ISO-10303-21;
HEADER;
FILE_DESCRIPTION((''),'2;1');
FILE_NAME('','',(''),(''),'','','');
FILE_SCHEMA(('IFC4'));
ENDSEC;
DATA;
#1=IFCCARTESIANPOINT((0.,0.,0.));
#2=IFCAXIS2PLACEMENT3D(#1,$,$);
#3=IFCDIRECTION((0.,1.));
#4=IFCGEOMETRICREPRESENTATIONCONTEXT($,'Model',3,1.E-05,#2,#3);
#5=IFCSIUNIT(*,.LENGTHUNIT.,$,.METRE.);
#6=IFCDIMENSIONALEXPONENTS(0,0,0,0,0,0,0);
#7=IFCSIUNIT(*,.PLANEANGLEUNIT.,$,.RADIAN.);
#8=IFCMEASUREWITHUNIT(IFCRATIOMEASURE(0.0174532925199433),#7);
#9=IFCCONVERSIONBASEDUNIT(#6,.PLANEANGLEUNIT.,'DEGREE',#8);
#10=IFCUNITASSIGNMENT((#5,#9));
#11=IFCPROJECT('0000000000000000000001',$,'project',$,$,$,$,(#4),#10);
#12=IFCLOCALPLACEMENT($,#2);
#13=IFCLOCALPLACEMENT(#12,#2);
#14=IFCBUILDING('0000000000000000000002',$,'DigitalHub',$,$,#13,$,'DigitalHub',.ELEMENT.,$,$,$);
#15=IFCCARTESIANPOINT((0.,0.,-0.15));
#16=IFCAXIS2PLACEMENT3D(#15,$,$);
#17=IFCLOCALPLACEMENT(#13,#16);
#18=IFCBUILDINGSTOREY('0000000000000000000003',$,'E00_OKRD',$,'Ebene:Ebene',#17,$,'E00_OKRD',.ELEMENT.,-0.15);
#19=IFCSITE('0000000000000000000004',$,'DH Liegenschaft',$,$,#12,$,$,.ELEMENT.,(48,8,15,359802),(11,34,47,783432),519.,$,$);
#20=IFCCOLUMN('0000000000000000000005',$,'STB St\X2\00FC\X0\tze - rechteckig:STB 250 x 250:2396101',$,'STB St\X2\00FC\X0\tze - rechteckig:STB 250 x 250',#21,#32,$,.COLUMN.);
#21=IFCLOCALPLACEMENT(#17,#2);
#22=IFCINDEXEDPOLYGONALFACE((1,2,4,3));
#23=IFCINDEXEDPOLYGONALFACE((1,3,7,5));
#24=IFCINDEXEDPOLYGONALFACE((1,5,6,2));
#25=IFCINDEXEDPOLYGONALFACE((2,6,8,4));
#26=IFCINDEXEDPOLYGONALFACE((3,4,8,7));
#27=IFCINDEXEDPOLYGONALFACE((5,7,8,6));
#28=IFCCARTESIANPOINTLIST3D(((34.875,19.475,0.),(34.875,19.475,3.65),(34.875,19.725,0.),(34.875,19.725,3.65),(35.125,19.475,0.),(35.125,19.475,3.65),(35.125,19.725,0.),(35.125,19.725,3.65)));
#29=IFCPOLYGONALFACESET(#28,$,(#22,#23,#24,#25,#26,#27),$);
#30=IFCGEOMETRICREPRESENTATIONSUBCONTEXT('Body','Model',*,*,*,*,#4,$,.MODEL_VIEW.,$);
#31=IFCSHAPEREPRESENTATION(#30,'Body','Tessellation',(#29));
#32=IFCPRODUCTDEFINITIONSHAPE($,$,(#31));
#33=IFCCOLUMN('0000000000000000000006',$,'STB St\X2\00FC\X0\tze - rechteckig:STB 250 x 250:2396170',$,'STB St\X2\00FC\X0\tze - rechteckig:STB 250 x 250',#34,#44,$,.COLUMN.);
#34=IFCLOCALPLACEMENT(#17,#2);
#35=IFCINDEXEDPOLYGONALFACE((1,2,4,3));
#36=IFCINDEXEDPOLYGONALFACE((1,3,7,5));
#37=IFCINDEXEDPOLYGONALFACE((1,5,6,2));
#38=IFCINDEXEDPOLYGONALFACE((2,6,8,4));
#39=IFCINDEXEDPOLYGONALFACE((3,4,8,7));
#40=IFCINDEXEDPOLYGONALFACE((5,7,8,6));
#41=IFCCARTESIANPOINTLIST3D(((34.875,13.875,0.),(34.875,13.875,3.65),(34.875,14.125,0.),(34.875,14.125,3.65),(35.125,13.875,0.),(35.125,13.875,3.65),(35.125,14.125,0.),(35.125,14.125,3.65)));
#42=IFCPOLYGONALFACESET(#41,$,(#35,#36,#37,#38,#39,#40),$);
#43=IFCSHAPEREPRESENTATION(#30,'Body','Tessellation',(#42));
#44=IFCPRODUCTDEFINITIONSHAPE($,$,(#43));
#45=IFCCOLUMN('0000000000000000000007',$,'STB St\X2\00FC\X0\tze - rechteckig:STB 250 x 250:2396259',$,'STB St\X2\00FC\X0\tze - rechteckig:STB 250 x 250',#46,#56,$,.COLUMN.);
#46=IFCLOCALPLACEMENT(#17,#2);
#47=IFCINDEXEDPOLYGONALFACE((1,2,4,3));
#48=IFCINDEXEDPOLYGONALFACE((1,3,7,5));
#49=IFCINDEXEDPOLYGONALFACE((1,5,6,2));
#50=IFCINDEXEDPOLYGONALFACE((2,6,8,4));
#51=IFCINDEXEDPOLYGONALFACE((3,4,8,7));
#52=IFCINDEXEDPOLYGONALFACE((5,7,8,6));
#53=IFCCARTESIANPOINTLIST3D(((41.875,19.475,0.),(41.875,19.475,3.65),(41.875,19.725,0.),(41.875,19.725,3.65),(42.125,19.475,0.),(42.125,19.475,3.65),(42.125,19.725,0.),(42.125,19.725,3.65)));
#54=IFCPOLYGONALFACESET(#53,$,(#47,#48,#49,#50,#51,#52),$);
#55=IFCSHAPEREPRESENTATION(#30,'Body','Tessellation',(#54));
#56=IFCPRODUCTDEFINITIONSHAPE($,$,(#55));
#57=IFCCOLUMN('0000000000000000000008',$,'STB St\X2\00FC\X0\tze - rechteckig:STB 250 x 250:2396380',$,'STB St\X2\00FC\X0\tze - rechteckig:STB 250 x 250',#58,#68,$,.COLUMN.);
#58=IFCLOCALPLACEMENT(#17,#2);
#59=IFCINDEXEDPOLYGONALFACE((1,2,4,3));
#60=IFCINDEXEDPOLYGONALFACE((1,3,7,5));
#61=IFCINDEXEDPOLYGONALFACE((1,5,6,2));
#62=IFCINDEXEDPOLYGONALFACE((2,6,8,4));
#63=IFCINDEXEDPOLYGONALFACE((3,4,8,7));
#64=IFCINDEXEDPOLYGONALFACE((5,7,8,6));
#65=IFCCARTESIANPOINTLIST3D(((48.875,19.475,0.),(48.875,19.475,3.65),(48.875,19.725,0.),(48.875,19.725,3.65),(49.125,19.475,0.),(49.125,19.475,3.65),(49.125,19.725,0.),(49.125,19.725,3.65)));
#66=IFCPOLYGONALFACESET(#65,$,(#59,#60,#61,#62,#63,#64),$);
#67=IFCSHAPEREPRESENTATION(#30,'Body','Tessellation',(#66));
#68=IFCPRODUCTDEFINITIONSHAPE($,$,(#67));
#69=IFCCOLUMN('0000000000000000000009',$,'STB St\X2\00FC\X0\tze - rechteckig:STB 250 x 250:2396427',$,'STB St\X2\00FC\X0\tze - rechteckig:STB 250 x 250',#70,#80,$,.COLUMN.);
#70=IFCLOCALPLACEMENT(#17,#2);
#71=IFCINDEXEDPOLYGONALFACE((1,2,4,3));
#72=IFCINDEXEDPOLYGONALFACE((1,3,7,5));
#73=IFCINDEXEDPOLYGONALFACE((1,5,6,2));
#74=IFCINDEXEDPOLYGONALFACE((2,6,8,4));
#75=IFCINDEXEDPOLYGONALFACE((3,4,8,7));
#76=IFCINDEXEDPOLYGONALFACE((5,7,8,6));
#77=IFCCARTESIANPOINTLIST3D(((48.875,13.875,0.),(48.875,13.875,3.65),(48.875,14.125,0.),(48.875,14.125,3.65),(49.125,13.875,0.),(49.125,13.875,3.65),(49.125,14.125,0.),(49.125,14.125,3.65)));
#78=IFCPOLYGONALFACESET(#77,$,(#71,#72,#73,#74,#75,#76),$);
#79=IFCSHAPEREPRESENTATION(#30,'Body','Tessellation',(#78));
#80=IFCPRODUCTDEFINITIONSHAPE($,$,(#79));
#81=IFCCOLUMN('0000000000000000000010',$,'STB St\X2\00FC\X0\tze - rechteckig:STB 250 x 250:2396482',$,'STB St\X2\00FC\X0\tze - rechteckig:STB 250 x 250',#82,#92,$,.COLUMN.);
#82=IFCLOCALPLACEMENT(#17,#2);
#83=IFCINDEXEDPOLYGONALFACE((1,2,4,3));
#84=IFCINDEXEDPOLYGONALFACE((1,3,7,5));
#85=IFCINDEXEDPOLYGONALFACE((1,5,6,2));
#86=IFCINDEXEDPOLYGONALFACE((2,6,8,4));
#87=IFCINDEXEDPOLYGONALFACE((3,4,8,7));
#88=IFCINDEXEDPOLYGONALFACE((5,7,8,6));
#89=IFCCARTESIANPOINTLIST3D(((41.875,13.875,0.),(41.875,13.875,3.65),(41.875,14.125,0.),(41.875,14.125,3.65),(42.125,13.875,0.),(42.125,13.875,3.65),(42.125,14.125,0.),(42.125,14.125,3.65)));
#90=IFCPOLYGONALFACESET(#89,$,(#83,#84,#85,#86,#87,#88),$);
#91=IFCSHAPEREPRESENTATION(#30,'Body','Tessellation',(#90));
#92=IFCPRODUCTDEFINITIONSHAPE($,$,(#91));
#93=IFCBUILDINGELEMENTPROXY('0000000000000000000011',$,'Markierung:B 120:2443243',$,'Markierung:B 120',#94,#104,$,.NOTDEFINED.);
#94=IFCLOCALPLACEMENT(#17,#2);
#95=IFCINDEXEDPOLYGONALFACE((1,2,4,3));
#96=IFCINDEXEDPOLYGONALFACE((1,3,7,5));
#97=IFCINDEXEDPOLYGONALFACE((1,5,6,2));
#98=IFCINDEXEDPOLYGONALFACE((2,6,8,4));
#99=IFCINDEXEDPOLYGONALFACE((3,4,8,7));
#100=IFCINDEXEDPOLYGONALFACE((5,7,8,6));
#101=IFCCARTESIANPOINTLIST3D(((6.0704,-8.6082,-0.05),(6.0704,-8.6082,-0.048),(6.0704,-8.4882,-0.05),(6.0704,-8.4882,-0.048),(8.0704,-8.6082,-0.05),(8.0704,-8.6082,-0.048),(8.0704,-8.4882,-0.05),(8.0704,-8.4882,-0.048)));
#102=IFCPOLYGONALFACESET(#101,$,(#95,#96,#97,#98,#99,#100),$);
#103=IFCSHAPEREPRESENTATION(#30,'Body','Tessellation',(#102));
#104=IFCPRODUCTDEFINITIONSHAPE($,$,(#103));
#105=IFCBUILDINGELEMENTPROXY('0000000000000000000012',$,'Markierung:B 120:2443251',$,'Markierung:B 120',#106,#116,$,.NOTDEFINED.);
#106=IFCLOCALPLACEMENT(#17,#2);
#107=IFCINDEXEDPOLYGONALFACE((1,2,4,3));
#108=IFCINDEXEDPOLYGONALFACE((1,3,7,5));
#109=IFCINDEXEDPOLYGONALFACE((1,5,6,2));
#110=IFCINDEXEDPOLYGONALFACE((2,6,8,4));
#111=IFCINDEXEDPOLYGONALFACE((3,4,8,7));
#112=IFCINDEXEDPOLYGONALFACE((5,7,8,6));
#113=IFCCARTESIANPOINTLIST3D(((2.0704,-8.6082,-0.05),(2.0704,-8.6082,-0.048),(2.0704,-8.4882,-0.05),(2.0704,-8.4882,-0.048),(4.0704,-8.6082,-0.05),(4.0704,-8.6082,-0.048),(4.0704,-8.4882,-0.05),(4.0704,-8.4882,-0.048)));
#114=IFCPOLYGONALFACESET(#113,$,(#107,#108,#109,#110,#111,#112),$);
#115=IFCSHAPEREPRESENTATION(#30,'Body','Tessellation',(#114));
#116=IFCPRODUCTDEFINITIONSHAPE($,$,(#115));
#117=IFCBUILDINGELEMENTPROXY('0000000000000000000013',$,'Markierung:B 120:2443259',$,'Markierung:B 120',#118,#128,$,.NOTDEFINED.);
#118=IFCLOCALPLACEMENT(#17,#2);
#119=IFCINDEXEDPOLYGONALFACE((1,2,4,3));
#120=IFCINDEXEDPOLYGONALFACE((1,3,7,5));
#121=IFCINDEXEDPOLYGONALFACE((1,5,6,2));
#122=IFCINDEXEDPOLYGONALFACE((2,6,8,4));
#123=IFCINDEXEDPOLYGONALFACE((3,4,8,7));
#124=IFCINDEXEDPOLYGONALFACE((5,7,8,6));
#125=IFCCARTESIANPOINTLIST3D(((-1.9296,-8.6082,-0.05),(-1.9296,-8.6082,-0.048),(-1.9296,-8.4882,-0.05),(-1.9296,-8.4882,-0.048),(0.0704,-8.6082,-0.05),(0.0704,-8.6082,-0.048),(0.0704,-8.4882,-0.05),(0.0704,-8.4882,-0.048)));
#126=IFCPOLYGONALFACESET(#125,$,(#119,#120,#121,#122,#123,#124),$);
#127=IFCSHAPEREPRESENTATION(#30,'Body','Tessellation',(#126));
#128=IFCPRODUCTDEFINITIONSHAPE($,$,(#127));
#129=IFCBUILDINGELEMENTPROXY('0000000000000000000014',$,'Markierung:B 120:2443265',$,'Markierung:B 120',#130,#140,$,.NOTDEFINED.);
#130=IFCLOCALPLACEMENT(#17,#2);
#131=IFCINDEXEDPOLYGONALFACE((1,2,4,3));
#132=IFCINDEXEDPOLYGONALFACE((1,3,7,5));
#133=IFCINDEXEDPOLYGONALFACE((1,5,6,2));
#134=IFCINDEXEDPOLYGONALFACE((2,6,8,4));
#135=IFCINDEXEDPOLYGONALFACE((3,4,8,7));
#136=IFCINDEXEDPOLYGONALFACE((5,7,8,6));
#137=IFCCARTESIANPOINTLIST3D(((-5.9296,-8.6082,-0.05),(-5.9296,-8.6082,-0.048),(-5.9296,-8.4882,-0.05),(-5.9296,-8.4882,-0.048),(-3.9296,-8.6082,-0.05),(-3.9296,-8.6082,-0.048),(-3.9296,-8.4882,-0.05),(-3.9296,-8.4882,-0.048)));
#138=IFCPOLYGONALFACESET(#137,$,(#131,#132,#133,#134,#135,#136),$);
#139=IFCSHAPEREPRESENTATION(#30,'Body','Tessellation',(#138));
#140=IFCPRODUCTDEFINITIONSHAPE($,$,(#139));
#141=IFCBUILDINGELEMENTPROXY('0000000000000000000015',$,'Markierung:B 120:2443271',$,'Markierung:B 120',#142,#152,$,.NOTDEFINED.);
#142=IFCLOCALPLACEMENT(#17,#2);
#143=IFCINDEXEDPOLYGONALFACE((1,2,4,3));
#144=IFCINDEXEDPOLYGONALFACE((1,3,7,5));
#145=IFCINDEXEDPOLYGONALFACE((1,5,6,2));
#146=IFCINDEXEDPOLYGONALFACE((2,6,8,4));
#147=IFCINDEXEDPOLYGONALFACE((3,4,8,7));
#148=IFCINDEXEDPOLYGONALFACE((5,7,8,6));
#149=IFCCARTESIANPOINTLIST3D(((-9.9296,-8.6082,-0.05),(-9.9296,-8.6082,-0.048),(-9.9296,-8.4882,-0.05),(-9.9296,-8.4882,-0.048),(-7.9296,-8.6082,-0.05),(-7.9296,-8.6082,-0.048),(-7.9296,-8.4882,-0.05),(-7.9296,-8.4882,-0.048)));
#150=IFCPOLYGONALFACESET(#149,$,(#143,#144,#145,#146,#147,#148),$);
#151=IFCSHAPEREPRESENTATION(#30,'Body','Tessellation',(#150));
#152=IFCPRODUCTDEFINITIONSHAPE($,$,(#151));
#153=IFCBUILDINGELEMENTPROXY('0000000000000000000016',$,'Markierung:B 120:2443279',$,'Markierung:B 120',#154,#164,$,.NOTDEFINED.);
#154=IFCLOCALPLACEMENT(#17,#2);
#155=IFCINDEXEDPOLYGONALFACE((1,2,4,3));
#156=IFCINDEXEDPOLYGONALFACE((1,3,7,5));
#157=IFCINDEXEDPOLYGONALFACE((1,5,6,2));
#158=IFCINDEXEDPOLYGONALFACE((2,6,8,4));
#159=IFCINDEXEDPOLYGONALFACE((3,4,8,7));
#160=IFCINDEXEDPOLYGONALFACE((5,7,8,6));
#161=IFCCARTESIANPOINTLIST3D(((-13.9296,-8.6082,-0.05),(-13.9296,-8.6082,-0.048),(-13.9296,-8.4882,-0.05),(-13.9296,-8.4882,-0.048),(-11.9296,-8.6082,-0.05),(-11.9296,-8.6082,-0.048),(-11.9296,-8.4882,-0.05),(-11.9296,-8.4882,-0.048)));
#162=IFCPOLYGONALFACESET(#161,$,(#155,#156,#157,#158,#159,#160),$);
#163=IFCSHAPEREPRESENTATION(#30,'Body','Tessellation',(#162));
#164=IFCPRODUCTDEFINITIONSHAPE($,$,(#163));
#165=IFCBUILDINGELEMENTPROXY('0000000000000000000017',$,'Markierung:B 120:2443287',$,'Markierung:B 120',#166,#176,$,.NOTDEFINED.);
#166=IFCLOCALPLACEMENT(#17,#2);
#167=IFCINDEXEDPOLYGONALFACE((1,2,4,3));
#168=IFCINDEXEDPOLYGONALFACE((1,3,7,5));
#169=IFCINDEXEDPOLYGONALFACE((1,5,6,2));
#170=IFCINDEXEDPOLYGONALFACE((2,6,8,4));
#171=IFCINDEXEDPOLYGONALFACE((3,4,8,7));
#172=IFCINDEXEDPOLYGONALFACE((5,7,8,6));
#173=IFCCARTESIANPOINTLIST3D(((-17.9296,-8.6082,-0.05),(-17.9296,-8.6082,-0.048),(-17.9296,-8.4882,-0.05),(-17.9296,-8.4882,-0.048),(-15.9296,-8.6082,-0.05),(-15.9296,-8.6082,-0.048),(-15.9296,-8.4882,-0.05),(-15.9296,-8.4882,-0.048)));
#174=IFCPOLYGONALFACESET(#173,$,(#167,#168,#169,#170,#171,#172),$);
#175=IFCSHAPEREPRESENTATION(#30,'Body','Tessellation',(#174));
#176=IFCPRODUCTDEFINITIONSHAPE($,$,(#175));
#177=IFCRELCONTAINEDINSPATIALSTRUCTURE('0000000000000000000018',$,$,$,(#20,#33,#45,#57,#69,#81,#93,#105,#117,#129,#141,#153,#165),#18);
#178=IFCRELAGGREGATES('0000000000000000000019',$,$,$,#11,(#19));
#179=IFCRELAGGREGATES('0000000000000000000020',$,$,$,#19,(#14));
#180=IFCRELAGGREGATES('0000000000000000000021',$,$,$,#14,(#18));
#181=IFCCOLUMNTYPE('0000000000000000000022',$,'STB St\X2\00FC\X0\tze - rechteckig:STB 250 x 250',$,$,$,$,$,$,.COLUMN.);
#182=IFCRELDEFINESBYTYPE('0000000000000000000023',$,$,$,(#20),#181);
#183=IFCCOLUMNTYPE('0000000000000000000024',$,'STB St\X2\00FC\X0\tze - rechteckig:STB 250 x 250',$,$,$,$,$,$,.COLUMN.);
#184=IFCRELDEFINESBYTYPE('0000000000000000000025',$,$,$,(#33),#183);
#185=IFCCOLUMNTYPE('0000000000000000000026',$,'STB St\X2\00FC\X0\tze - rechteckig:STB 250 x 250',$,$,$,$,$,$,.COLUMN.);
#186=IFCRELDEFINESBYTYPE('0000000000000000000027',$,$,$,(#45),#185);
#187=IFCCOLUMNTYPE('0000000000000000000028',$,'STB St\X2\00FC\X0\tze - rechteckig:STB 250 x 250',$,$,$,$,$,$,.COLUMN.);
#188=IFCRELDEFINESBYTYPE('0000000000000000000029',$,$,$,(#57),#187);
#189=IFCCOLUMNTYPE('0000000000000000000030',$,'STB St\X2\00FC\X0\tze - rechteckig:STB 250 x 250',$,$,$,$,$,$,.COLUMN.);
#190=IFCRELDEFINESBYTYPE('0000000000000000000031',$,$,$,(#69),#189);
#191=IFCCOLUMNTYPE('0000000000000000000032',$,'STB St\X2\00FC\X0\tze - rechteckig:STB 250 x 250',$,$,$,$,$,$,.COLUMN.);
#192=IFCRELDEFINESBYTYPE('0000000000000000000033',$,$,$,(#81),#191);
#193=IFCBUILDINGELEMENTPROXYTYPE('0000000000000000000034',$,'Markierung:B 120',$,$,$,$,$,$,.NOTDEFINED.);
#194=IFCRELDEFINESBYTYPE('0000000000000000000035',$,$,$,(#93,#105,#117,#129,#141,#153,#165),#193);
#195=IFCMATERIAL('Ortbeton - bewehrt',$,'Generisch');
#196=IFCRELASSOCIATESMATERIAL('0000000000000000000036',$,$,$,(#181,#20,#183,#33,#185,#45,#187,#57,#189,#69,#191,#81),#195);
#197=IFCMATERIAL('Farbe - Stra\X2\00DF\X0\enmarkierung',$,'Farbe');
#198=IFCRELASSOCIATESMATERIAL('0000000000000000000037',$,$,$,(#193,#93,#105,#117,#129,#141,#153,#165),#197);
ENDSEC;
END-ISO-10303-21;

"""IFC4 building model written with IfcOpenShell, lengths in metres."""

from ifc_helpers import new_model, entity, si_unit, converted_unit, direction, frame, origin, place, context, subcontext, project, spatial, indexed_curve, outline, extrude, source, transform, mapped, material, type_object, type_shapes, element, save


model = new_model("IFC4")

# Units and contexts
model_context = context("Model", 3, precision=1e-05, world=origin(), true_north=direction((0.0, 1.0)))
body_context = subcontext(model_context, "Body", "Model", "MODEL_VIEW")
ifc_project = project(units=[si_unit("LENGTHUNIT", "METRE"), converted_unit("PLANEANGLEUNIT", "DEGREE", entity("IfcRatioMeasure", 0.0174532925199433), si_unit("PLANEANGLEUNIT", "RADIAN"), dimensions=[0, 0, 0, 0, 0, 0, 0])], contexts=[model_context])

# Site, building, storey
site_placement = place(None, frame((0.0, 0.0, 0.0)))
site = spatial("IfcSite", under=ifc_project, at=site_placement, Name="DH Liegenschaft", CompositionType="ELEMENT", RefLatitude=(48, 8, 15, 359802), RefLongitude=(11, 34, 47, 783432), RefElevation=519.0)
building_placement = place(site_placement, origin())
building = spatial("IfcBuilding", under=site, at=building_placement, Name="DigitalHub", LongName="DigitalHub", CompositionType="ELEMENT")
storey_placement = place(building_placement, frame((0.0, 0.0, -0.15)))
storey = spatial("IfcBuildingStorey", under=building, at=storey_placement, Name="E00_OKRD", ObjectType="Ebene:Ebene", LongName="E00_OKRD", CompositionType="ELEMENT", Elevation=-0.15)

# Columns
ifc_material_1 = material(Name="Ortbeton - bewehrt", Category="Generisch")
column_type_1 = type_object("IfcColumnType", Name="STB Stütze - rechteckig:STB 250 x 250", PredefinedType="COLUMN", material=ifc_material_1)
shared_shape_1 = source(origin(), body_context, "Body", "SweptSolid", [
    extrude(outline(indexed_curve([(-0.125, -0.125), (0.125, -0.125), (0.125, 0.125), (-0.125, 0.125), (-0.125, -0.125)], self_intersect=False)), frame((35.0, 19.6, -0.15), z_axis=(0.0, 0.0, 1.0), x_axis=(0.0, -1.0, 0.0)), (0.0, 0.0, 1.0), 3.65),
])
type_shapes(column_type_1, [shared_shape_1])
column_1_placement = place(storey_placement, frame((0.0, 0.0, 0.15)))
element("IfcColumn", 1, at=column_1_placement, inside=storey, type_object=column_type_1, material=ifc_material_1, Name="STB Stütze - rechteckig:STB 250 x 250:2396101", ObjectType="STB Stütze - rechteckig:STB 250 x 250", PredefinedType="COLUMN", context=body_context, shape_type="MappedRepresentation", body=[
    mapped(shared_shape_1, transform((0.0, 0.0, 0.0), scale=1.0)),
])
column_type_2 = type_object("IfcColumnType", Name="STB Stütze - rechteckig:STB 250 x 250", PredefinedType="COLUMN", material=ifc_material_1)
shared_shape_2 = source(origin(), body_context, "Body", "SweptSolid", [
    extrude(outline(indexed_curve([(-0.125, -0.125), (0.125, -0.125), (0.125, 0.125), (-0.125, 0.125), (-0.125, -0.125)], self_intersect=False)), frame((35.0, 14.0, -0.15), z_axis=(0.0, 0.0, 1.0), x_axis=(0.0, -1.0, 0.0)), (0.0, 0.0, 1.0), 3.65),
])
type_shapes(column_type_2, [shared_shape_2])
column_2_placement = place(storey_placement, frame((0.0, 0.0, 0.15)))
element("IfcColumn", 2, at=column_2_placement, inside=storey, type_object=column_type_2, material=ifc_material_1, Name="STB Stütze - rechteckig:STB 250 x 250:2396170", ObjectType="STB Stütze - rechteckig:STB 250 x 250", PredefinedType="COLUMN", context=body_context, shape_type="MappedRepresentation", body=[
    mapped(shared_shape_2, transform((0.0, 0.0, 0.0), scale=1.0)),
])
column_type_3 = type_object("IfcColumnType", Name="STB Stütze - rechteckig:STB 250 x 250", PredefinedType="COLUMN", material=ifc_material_1)
shared_shape_3 = source(origin(), body_context, "Body", "SweptSolid", [
    extrude(outline(indexed_curve([(-0.125, -0.125), (0.125, -0.125), (0.125, 0.125), (-0.125, 0.125), (-0.125, -0.125)], self_intersect=False)), frame((42.0, 19.6, -0.15), z_axis=(0.0, 0.0, 1.0), x_axis=(0.0, -1.0, 0.0)), (0.0, 0.0, 1.0), 3.65),
])
type_shapes(column_type_3, [shared_shape_3])
column_3_placement = place(storey_placement, frame((0.0, 0.0, 0.15)))
element("IfcColumn", 3, at=column_3_placement, inside=storey, type_object=column_type_3, material=ifc_material_1, Name="STB Stütze - rechteckig:STB 250 x 250:2396259", ObjectType="STB Stütze - rechteckig:STB 250 x 250", PredefinedType="COLUMN", context=body_context, shape_type="MappedRepresentation", body=[
    mapped(shared_shape_3, transform((0.0, 0.0, 0.0), scale=1.0)),
])
column_type_4 = type_object("IfcColumnType", Name="STB Stütze - rechteckig:STB 250 x 250", PredefinedType="COLUMN", material=ifc_material_1)
shared_shape_4 = source(origin(), body_context, "Body", "SweptSolid", [
    extrude(outline(indexed_curve([(-0.125, -0.125), (0.125, -0.125), (0.125, 0.125), (-0.125, 0.125), (-0.125, -0.125)], self_intersect=False)), frame((49.0, 19.6, -0.15), z_axis=(0.0, 0.0, 1.0), x_axis=(0.0, -1.0, 0.0)), (0.0, 0.0, 1.0), 3.65),
])
type_shapes(column_type_4, [shared_shape_4])
column_4_placement = place(storey_placement, frame((0.0, 0.0, 0.15)))
element("IfcColumn", 4, at=column_4_placement, inside=storey, type_object=column_type_4, material=ifc_material_1, Name="STB Stütze - rechteckig:STB 250 x 250:2396380", ObjectType="STB Stütze - rechteckig:STB 250 x 250", PredefinedType="COLUMN", context=body_context, shape_type="MappedRepresentation", body=[
    mapped(shared_shape_4, transform((0.0, 0.0, 0.0), scale=1.0)),
])
column_type_5 = type_object("IfcColumnType", Name="STB Stütze - rechteckig:STB 250 x 250", PredefinedType="COLUMN", material=ifc_material_1)
shared_shape_5 = source(origin(), body_context, "Body", "SweptSolid", [
    extrude(outline(indexed_curve([(-0.125, -0.125), (0.125, -0.125), (0.125, 0.125), (-0.125, 0.125), (-0.125, -0.125)], self_intersect=False)), frame((49.0, 14.0, -0.15), z_axis=(0.0, 0.0, 1.0), x_axis=(0.0, -1.0, 0.0)), (0.0, 0.0, 1.0), 3.65),
])
type_shapes(column_type_5, [shared_shape_5])
column_5_placement = place(storey_placement, frame((0.0, 0.0, 0.15)))
element("IfcColumn", 5, at=column_5_placement, inside=storey, type_object=column_type_5, material=ifc_material_1, Name="STB Stütze - rechteckig:STB 250 x 250:2396427", ObjectType="STB Stütze - rechteckig:STB 250 x 250", PredefinedType="COLUMN", context=body_context, shape_type="MappedRepresentation", body=[
    mapped(shared_shape_5, transform((0.0, 0.0, 0.0), scale=1.0)),
])
column_type_6 = type_object("IfcColumnType", Name="STB Stütze - rechteckig:STB 250 x 250", PredefinedType="COLUMN", material=ifc_material_1)
shared_shape_6 = source(origin(), body_context, "Body", "SweptSolid", [
    extrude(outline(indexed_curve([(-0.125, -0.125), (0.125, -0.125), (0.125, 0.125), (-0.125, 0.125), (-0.125, -0.125)], self_intersect=False)), frame((42.0, 14.0, -0.15), z_axis=(0.0, 0.0, 1.0), x_axis=(0.0, -1.0, 0.0)), (0.0, 0.0, 1.0), 3.65),
])
type_shapes(column_type_6, [shared_shape_6])
column_6_placement = place(storey_placement, frame((0.0, 0.0, 0.15)))
element("IfcColumn", 6, at=column_6_placement, inside=storey, type_object=column_type_6, material=ifc_material_1, Name="STB Stütze - rechteckig:STB 250 x 250:2396482", ObjectType="STB Stütze - rechteckig:STB 250 x 250", PredefinedType="COLUMN", context=body_context, shape_type="MappedRepresentation", body=[
    mapped(shared_shape_6, transform((0.0, 0.0, 0.0), scale=1.0)),
])

# Building element proxies
ifc_material_2 = material(Name="Farbe - Straßenmarkierung", Category="Farbe")
building_element_proxy_type = type_object("IfcBuildingElementProxyType", Name="Markierung:B 120", PredefinedType="NOTDEFINED", material=ifc_material_2)
shared_shape_7 = source(origin(), body_context, "Body", "SweptSolid", [
    extrude(outline(indexed_curve([(-0.06, -1.0), (0.06, -1.0), (0.06, 1.0), (-0.06, 1.0), (-0.06, -1.0)], self_intersect=False)), frame((0.06, 1.0, 0.0), z_axis=(0.0, 0.0, 1.0), x_axis=(-1.0, 0.0, 0.0)), (0.0, 0.0, 1.0), 0.002),
])
type_shapes(building_element_proxy_type, [shared_shape_7])
for number, where, z_axis, x_axis, name in (
    (7, (8.0704, -8.6082, -0.05), (0.0, 0.0, 1.0), (0.0, 1.0, 0.0), "Markierung:B 120:2443243"),
    (8, (4.0704, -8.6082, -0.05), (0.0, 0.0, 1.0), (0.0, 1.0, 0.0), "Markierung:B 120:2443251"),
    (9, (0.0704, -8.6082, -0.05), (0.0, 0.0, 1.0), (0.0, 1.0, 0.0), "Markierung:B 120:2443259"),
    (10, (-3.9296, -8.6082, -0.05), (0.0, 0.0, 1.0), (0.0, 1.0, 0.0), "Markierung:B 120:2443265"),
    (11, (-7.9296, -8.6082, -0.05), (0.0, 0.0, 1.0), (0.0, 1.0, 0.0), "Markierung:B 120:2443271"),
    (12, (-11.9296, -8.6082, -0.05), (0.0, 0.0, 1.0), (0.0, 1.0, 0.0), "Markierung:B 120:2443279"),
    (13, (-15.9296, -8.6082, -0.05), (0.0, 0.0, 1.0), (0.0, 1.0, 0.0), "Markierung:B 120:2443287"),
):
    element("IfcBuildingElementProxy", number, at=place(storey_placement, frame(where, z_axis=z_axis, x_axis=x_axis)), inside=storey, type_object=building_element_proxy_type, material=ifc_material_2, Name=name, ObjectType="Markierung:B 120", PredefinedType="NOTDEFINED", context=body_context, shape_type="MappedRepresentation", body=[
        mapped(shared_shape_7, transform((0.0, 0.0, 0.0), scale=1.0)),
    ])

save(model, "model.ifc")
